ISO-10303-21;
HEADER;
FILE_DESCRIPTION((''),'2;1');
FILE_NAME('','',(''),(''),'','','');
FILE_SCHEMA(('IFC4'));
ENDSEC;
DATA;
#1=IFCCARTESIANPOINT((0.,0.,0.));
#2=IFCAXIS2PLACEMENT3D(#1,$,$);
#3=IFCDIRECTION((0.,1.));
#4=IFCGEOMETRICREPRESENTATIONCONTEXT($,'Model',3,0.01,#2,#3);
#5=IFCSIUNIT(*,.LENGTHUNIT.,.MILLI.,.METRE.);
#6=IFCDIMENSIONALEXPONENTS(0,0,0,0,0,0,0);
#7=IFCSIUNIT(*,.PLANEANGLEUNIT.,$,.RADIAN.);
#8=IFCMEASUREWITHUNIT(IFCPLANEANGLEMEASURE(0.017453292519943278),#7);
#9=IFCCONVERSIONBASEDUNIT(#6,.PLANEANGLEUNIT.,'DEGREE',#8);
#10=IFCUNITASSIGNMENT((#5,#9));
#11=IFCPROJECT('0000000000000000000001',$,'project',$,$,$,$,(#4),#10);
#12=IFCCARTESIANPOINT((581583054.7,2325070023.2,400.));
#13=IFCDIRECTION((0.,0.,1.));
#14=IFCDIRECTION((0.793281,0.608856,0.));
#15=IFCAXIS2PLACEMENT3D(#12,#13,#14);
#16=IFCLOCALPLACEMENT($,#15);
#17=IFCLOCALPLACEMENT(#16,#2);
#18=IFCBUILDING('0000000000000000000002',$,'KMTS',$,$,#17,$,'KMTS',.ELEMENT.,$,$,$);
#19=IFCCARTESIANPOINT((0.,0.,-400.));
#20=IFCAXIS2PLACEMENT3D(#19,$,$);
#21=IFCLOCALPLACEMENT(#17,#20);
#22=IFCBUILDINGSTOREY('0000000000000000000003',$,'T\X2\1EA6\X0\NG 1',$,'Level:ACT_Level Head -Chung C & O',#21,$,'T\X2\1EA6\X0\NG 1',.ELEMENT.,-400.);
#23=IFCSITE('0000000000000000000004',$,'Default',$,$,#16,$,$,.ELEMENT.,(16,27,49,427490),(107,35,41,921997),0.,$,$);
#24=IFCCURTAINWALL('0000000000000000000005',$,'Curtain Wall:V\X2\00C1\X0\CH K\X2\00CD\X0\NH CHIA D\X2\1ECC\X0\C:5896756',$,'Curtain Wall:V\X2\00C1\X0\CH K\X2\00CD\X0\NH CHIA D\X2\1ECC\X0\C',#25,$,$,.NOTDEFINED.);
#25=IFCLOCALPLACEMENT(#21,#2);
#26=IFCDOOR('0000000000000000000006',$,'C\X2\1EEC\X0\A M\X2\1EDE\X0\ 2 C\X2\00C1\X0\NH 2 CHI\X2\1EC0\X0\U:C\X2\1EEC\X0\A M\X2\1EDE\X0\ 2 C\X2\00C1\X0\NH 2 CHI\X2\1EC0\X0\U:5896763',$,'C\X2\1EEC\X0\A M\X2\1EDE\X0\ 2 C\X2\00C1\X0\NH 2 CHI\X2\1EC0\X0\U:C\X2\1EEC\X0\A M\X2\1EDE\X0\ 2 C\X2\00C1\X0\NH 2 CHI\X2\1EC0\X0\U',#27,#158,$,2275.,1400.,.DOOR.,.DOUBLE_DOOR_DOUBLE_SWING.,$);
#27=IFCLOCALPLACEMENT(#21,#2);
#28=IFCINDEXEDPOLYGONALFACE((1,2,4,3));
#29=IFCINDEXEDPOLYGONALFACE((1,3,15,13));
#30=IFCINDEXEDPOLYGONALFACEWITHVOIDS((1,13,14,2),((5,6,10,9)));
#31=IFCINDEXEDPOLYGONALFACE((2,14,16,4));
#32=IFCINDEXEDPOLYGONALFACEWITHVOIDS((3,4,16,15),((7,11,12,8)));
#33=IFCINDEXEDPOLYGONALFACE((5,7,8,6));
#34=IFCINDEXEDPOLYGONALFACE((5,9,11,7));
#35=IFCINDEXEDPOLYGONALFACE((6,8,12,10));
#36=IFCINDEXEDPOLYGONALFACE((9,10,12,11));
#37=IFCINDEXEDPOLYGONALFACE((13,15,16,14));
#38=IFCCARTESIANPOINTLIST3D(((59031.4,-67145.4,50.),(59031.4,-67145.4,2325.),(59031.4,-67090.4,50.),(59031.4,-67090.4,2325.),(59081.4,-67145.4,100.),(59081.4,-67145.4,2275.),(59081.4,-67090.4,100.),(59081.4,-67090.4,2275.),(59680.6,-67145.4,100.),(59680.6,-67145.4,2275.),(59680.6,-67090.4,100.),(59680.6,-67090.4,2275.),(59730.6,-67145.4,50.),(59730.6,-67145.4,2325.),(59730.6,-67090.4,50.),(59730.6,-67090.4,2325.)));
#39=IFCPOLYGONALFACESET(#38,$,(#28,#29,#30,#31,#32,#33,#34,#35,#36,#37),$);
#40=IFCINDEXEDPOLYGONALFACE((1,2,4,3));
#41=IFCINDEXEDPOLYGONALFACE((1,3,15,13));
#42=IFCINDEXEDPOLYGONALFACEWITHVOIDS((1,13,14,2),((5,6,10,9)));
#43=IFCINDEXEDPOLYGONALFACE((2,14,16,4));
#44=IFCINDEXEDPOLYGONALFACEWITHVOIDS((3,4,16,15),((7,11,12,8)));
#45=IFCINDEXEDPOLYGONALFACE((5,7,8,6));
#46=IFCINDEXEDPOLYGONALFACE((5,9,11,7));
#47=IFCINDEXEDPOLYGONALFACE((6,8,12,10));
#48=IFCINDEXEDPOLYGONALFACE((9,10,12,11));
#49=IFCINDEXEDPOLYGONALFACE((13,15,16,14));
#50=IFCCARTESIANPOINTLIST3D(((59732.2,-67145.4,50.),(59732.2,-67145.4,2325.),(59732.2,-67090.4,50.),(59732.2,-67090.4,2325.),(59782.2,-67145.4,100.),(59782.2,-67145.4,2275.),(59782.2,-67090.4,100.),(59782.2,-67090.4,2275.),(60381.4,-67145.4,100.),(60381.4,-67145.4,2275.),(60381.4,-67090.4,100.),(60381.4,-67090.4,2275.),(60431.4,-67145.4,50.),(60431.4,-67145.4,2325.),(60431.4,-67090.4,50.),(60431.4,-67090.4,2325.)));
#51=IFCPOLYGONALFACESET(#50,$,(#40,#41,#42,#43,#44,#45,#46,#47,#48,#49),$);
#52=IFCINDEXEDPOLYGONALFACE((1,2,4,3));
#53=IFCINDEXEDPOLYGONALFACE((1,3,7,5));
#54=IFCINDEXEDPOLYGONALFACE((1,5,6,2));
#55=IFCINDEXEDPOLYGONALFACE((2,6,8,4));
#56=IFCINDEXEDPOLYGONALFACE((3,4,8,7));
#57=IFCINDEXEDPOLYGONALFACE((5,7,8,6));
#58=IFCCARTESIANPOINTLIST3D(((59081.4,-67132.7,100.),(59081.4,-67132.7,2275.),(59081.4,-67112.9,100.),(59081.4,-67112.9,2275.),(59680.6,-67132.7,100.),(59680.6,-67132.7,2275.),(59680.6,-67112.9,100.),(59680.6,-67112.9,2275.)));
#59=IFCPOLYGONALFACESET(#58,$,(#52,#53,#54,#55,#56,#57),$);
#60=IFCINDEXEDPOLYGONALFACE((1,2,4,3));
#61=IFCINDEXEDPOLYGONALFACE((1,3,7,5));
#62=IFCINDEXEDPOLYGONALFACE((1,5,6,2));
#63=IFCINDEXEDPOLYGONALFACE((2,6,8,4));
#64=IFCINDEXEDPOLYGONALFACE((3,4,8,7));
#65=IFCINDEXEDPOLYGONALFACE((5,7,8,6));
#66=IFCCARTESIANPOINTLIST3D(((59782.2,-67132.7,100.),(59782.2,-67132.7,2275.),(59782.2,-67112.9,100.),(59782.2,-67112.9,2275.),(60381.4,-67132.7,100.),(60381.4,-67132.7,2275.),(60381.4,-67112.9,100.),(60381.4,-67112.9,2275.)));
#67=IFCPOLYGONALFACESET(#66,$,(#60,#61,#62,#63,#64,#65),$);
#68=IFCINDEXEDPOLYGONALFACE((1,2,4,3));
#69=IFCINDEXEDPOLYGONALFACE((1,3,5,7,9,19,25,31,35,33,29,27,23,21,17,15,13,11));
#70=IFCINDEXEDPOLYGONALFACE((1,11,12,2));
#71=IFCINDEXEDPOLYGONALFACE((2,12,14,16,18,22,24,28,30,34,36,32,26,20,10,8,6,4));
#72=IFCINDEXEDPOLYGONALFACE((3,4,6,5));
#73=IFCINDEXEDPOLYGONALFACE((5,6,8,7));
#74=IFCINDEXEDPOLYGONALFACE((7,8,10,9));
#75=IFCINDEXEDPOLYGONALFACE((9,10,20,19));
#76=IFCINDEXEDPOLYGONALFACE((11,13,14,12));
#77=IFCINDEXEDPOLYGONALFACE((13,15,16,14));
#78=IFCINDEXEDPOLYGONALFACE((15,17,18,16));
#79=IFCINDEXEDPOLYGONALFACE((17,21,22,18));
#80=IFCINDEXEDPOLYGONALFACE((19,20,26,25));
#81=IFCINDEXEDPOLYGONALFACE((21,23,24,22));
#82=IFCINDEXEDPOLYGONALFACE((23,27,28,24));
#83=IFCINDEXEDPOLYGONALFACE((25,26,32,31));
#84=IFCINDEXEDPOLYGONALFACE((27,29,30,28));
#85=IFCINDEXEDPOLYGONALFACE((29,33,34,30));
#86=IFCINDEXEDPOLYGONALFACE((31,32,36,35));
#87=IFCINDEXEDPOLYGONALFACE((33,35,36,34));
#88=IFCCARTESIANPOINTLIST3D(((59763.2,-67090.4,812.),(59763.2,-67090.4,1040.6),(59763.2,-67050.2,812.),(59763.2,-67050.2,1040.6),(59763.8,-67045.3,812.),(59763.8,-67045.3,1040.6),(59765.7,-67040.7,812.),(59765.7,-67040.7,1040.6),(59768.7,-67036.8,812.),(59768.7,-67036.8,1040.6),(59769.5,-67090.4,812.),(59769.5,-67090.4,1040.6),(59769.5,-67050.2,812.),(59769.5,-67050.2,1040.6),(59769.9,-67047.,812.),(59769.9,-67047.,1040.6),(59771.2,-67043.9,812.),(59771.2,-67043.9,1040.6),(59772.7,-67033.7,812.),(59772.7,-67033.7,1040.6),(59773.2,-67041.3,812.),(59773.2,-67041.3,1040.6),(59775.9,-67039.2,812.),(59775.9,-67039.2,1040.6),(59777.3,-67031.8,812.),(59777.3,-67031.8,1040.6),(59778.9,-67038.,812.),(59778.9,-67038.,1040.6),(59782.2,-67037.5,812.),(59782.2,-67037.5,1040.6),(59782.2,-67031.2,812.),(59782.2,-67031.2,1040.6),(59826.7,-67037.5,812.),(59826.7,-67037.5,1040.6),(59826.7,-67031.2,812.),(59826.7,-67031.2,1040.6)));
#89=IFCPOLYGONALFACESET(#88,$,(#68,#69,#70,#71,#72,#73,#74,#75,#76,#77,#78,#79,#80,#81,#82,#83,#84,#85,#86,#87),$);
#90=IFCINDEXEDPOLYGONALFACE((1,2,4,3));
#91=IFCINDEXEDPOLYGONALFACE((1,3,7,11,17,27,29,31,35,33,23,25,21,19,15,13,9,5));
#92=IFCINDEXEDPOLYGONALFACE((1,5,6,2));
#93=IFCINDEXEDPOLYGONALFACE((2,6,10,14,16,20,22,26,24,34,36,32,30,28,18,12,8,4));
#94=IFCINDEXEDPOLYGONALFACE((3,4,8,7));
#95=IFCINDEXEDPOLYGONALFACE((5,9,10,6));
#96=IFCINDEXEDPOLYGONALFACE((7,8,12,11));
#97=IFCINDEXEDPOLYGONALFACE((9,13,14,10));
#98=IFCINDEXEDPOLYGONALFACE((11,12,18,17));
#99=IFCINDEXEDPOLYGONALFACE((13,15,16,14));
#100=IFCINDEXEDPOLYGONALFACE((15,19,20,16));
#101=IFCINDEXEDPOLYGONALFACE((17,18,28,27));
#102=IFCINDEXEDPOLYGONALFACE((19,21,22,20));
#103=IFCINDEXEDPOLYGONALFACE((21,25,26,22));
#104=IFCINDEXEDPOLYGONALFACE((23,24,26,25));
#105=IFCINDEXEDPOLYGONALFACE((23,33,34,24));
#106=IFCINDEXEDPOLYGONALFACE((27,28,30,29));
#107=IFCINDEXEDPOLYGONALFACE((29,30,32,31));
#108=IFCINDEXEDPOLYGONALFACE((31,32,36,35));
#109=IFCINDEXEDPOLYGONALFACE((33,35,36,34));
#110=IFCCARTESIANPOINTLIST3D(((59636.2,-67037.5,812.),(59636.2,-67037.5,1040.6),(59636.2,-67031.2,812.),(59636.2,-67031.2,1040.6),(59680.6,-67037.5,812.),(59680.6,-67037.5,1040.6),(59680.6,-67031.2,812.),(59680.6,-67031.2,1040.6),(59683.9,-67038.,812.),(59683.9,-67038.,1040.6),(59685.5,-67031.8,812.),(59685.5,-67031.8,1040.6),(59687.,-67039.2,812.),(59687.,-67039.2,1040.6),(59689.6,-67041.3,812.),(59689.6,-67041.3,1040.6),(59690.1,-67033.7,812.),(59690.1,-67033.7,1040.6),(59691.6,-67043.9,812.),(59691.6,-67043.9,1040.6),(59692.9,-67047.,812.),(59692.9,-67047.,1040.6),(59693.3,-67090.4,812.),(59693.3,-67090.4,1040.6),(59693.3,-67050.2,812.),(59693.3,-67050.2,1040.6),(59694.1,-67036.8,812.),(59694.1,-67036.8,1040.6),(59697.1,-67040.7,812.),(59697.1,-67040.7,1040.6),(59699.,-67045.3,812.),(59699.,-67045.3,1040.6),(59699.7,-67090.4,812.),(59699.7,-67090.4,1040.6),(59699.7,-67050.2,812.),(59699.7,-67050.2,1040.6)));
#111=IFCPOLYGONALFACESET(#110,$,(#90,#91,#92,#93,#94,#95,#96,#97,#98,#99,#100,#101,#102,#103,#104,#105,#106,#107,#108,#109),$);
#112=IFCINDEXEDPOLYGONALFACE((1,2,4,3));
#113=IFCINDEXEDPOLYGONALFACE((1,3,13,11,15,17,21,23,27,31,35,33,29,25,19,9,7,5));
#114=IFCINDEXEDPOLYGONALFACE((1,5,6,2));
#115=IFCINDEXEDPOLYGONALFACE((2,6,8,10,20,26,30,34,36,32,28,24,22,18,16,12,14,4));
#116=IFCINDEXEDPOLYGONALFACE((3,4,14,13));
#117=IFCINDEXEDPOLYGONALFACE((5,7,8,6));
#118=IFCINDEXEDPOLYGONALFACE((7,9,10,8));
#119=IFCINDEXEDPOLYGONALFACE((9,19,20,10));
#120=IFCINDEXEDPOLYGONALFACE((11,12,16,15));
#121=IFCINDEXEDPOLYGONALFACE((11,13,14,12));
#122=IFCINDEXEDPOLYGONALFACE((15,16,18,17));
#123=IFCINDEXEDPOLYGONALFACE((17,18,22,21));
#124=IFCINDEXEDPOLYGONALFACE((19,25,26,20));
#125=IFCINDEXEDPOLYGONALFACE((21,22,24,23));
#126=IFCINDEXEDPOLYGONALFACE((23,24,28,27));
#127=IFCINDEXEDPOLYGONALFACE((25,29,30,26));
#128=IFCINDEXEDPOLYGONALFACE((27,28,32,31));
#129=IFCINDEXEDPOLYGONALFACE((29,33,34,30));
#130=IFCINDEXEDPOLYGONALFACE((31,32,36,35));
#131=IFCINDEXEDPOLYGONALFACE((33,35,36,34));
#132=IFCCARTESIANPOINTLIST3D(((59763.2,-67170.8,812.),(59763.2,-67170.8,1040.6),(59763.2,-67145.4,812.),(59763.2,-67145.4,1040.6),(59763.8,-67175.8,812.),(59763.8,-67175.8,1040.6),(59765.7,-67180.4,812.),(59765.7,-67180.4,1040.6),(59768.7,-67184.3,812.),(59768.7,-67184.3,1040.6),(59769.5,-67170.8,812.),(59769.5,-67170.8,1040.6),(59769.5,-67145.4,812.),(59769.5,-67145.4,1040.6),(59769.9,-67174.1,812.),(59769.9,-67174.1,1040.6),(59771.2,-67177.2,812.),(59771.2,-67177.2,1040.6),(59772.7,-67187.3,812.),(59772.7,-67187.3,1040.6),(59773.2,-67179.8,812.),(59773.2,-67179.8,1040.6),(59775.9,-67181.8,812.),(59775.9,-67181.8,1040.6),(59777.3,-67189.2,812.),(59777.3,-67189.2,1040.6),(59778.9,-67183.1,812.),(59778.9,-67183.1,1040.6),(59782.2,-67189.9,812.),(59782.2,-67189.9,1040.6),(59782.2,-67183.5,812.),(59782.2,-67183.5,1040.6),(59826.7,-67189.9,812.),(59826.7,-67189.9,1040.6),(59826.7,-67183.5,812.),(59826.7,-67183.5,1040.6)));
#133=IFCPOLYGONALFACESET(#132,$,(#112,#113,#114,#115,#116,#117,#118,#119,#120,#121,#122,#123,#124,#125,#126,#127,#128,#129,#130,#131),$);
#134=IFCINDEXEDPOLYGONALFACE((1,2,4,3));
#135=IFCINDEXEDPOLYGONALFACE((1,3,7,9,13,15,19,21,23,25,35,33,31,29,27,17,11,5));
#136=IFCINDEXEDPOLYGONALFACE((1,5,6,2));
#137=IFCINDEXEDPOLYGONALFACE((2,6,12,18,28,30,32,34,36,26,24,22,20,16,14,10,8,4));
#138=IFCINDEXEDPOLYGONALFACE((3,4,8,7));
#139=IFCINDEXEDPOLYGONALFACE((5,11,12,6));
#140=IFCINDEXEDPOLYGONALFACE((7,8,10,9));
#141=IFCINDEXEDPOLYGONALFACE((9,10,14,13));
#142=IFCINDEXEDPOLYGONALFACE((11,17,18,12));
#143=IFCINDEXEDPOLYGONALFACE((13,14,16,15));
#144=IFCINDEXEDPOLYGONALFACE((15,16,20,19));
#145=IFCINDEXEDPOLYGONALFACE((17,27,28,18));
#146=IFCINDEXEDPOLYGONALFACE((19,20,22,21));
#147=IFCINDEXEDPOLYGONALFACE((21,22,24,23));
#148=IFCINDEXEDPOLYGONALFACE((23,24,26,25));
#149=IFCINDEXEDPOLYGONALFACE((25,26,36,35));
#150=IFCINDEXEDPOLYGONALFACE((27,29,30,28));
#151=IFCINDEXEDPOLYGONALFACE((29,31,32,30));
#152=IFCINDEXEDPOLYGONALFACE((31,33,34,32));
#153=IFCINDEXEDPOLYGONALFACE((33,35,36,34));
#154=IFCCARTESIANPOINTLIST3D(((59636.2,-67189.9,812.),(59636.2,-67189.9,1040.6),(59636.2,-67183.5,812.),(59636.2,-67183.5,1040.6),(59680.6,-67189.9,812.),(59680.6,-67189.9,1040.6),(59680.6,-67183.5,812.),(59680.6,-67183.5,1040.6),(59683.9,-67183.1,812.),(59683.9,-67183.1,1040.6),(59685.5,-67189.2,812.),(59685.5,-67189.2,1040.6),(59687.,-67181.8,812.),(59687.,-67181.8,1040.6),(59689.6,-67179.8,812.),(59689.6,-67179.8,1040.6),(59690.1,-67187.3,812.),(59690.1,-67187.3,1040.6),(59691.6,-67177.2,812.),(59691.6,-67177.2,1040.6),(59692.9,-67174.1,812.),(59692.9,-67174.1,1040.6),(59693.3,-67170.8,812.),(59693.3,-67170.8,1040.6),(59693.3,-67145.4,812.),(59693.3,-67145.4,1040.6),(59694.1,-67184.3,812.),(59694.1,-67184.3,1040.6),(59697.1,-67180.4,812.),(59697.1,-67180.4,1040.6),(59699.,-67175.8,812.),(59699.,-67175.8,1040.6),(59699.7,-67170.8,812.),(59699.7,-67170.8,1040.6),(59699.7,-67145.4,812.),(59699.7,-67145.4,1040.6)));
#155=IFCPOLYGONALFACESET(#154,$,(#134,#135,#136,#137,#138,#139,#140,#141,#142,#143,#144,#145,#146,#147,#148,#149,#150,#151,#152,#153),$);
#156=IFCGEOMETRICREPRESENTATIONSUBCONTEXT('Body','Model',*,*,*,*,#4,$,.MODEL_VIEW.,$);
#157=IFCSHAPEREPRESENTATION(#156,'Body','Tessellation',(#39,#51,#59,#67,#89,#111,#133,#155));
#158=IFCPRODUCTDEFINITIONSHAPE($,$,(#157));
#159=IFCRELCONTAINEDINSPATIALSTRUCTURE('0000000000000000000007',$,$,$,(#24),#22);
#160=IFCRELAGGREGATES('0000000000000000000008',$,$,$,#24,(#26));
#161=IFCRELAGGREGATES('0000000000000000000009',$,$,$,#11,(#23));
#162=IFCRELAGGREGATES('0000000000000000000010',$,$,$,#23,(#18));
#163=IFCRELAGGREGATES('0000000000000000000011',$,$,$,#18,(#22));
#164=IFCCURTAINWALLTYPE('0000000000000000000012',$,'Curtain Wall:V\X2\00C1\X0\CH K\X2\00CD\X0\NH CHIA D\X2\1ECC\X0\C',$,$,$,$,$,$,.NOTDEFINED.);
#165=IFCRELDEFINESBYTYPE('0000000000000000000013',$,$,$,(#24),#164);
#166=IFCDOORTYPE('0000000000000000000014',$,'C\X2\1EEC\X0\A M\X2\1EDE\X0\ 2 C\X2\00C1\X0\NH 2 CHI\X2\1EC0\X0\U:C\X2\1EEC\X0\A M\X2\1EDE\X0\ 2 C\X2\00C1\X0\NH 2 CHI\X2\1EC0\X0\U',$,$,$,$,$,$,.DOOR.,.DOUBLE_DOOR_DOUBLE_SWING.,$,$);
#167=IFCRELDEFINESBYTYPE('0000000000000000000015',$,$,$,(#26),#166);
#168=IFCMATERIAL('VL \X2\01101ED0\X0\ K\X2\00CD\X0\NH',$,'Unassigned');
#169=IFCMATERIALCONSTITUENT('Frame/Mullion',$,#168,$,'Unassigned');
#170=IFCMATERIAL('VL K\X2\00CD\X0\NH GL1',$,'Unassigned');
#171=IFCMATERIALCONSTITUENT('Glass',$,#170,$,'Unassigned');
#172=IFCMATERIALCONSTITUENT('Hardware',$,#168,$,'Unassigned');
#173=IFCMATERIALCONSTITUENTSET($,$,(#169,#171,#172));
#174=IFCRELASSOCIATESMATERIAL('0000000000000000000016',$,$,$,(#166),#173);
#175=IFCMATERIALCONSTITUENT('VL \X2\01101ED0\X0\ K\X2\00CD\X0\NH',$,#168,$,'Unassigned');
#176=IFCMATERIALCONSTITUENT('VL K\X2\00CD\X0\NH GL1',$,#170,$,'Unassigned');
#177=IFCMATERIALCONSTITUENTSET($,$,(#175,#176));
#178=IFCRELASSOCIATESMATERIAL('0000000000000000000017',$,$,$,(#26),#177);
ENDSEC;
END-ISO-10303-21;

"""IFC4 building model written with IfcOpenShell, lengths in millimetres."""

from ifc_helpers import new_model, entity, si_unit, converted_unit, direction, frame, origin, place, context, subcontext, project, spatial, line, arc, indexed_curve, outline, extrude, source, transform, mapped, material, constituent, constituent_set, type_object, type_shapes, element, aggregate, save


model = new_model("IFC4")

# Units and contexts
model_context = context("Model", 3, precision=0.01, world=origin(), true_north=direction((0.0, 1.0)))
body_context = subcontext(model_context, "Body", "Model", "MODEL_VIEW")
ifc_project = project(units=[si_unit("LENGTHUNIT", "METRE", prefix="MILLI"), converted_unit("PLANEANGLEUNIT", "DEGREE", entity("IfcPlaneAngleMeasure", 0.017453292519943278), si_unit("PLANEANGLEUNIT", "RADIAN"), dimensions=[0, 0, 0, 0, 0, 0, 0])], contexts=[model_context])

# Site, building, storey
site_placement = place(None, frame((581583054.7, 2325070023.2, 400.0), z_axis=(0.0, 0.0, 1.0), x_axis=(0.793281, 0.608856, 0.0)))
site = spatial("IfcSite", under=ifc_project, at=site_placement, Name="Default", CompositionType="ELEMENT", RefLatitude=(16, 27, 49, 427490), RefLongitude=(107, 35, 41, 921997), RefElevation=0.0)
building_placement = place(site_placement, origin())
building = spatial("IfcBuilding", under=site, at=building_placement, Name="KMTS", LongName="KMTS", CompositionType="ELEMENT")
storey_placement = place(building_placement, frame((0.0, 0.0, -400.0)))
storey = spatial("IfcBuildingStorey", under=building, at=storey_placement, Name="TẦNG 1", ObjectType="Level:ACT_Level Head -Chung C & O", LongName="TẦNG 1", CompositionType="ELEMENT", Elevation=-400.0)

# Curtain wall
curtain_wall_type = type_object("IfcCurtainWallType", Name="Curtain Wall:VÁCH KÍNH CHIA DỌC", PredefinedType="NOTDEFINED")
curtain_wall_1_placement = place(storey_placement, frame((0.0, 0.0, 400.0)))
curtain_wall_1 = element("IfcCurtainWall", 1, at=curtain_wall_1_placement, inside=storey, type_object=curtain_wall_type, Name="Curtain Wall:VÁCH KÍNH CHIA DỌC:5896756", ObjectType="Curtain Wall:VÁCH KÍNH CHIA DỌC", PredefinedType="NOTDEFINED")
ifc_material_1 = material(Name="VL ĐỐ KÍNH", Category="Unassigned")

# Door
ifc_constituent_1 = constituent(ifc_material_1, Name="VL ĐỐ KÍNH", Category="Unassigned")
ifc_material_2 = material(Name="VL KÍNH GL1", Category="Unassigned")
ifc_constituent_2 = constituent(ifc_material_2, Name="VL KÍNH GL1", Category="Unassigned")
ifc_constituent_set_1 = constituent_set(constituents=[ifc_constituent_1, ifc_constituent_2])
ifc_constituent_3 = constituent(ifc_material_1, Name="Frame/Mullion", Category="Unassigned")
ifc_constituent_4 = constituent(ifc_material_2, Name="Glass", Category="Unassigned")
ifc_constituent_5 = constituent(ifc_material_1, Name="Hardware", Category="Unassigned")
ifc_constituent_set_2 = constituent_set(constituents=[ifc_constituent_3, ifc_constituent_4, ifc_constituent_5])
door_type_1 = type_object("IfcDoorType", Name="CỬA MỞ 2 CÁNH 2 CHIỀU:CỬA MỞ 2 CÁNH 2 CHIỀU", OperationType="DOUBLE_DOOR_DOUBLE_SWING", PredefinedType="DOOR", material=ifc_constituent_set_2)
shared_shape_1 = source(origin(), body_context, "Body", "SweptSolid", [
    extrude(outline(indexed_curve([(-1137.5, -349.6), (1137.5, -349.6), (1137.5, 349.6), (-1137.5, 349.6), (-1137.5, -349.6)], self_intersect=False), holes=[indexed_curve([(-1087.5, 299.6), (1087.5, 299.6), (1087.5, -299.6), (-1087.5, -299.6), (-1087.5, 299.6)], self_intersect=False)]), frame((350.4, 27.5, 1137.5), z_axis=(0.0, -1.0, 0.0), x_axis=(0.0, 0.0, -1.0)), (0.0, 0.0, 1.0), 55.0),
    extrude(outline(indexed_curve([(-349.6, -1137.5), (349.6, -1137.5), (349.6, 1137.5), (-349.6, 1137.5), (-349.6, -1137.5)], self_intersect=False), holes=[indexed_curve([(-299.6, -1087.5), (-299.6, 1087.5), (299.6, 1087.5), (299.6, -1087.5), (-299.6, -1087.5)], self_intersect=False)]), frame((-350.4, 27.5, 1137.5), z_axis=(0.0, -1.0, 0.0), x_axis=(-1.0, 0.0, 0.0)), (0.0, 0.0, 1.0), 55.0),
    extrude(outline(indexed_curve([(-299.6, -9.9), (299.6, -9.9), (299.6, 9.9), (-299.6, 9.9), (-299.6, -9.9)], self_intersect=False)), frame((350.4, 4.9, 50.0)), (0.0, 0.0, 1.0), 2175.0),
    extrude(outline(indexed_curve([(-299.6, -9.9), (299.6, -9.9), (299.6, 9.9), (-299.6, 9.9), (-299.6, -9.9)], self_intersect=False)), frame((-350.4, 4.9, 50.0)), (0.0, 0.0, 1.0), 2175.0),
    extrude(outline(indexed_curve([(-2.1, -22.2), (38.1, -22.2), (38.1, -15.9), (-2.1, -15.9), (-11.1, -12.2), (-14.8, -3.2), (-14.8, 41.3), (-21.2, 41.3), (-21.2, -3.2), (-15.6, -16.6)], segments=[line(1, 2, 3, 4), arc(4, 5, 6), line(6, 7, 8, 9), arc(9, 10, 1)], self_intersect=False)), frame((-54.0, -65.6, 762.0), z_axis=(0.0, 0.0, 1.0), x_axis=(0.0, 1.0, 0.0)), (0.0, 0.0, 1.0), 228.6),
    extrude(outline(indexed_curve([(22.2, 2.1), (16.6, 15.6), (3.2, 21.2), (-41.3, 21.2), (-41.3, 14.8), (3.2, 14.8), (12.2, 11.1), (15.9, 2.1), (15.9, -38.1), (22.2, -38.1)], segments=[arc(1, 2, 3), line(3, 4, 5, 6), arc(6, 7, 8), line(8, 9, 10, 1)], self_intersect=False)), frame((54.0, -65.6, 762.0), z_axis=(0.0, 0.0, 1.0), x_axis=(-1.0, 0.0, 0.0)), (0.0, 0.0, 1.0), 228.6),
    extrude(outline(indexed_curve([(-22.2, 1.6), (-16.6, -11.9), (-3.2, -17.5), (41.3, -17.5), (41.3, -11.1), (-3.2, -11.1), (-12.2, -7.4), (-15.9, 1.6), (-15.9, 27.0), (-22.2, 27.0)], segments=[arc(1, 2, 3), line(3, 4, 5, 6), arc(6, 7, 8), line(8, 9, 10, 1)], self_intersect=False)), frame((-54.0, 54.5, 762.0), z_axis=(0.0, 0.0, 1.0), x_axis=(-1.0, 0.0, 0.0)), (0.0, 0.0, 1.0), 228.6),
    extrude(outline(indexed_curve([(1.6, -22.2), (27.0, -22.2), (27.0, -15.9), (1.6, -15.9), (-7.4, -12.2), (-11.1, -3.2), (-11.1, 41.3), (-17.5, 41.3), (-17.5, -3.2), (-11.9, -16.6)], segments=[line(1, 2, 3, 4), arc(4, 5, 6), line(6, 7, 8, 9), arc(9, 10, 1)], self_intersect=False)), frame((54.0, 54.5, 762.0), z_axis=(0.0, 0.0, 1.0), x_axis=(0.0, -1.0, 0.0)), (0.0, 0.0, 1.0), 228.6),
])
type_shapes(door_type_1, [shared_shape_1])
door_1_placement = place(curtain_wall_1_placement, frame((59731.4, -67117.9, -350.0), z_axis=(0.0, 0.0, 1.0), x_axis=(-1.0, 0.0, 0.0)))
door_1 = element("IfcDoor", 2, at=door_1_placement, type_object=door_type_1, material=ifc_constituent_set_1, Name="CỬA MỞ 2 CÁNH 2 CHIỀU:CỬA MỞ 2 CÁNH 2 CHIỀU:5896763", ObjectType="CỬA MỞ 2 CÁNH 2 CHIỀU:CỬA MỞ 2 CÁNH 2 CHIỀU", OperationType="DOUBLE_DOOR_DOUBLE_SWING", OverallHeight=2275.0, OverallWidth=1400.0, PredefinedType="DOOR", context=body_context, shape_type="MappedRepresentation", body=[
    mapped(shared_shape_1, transform((0.0, 0.0, 0.0), scale=1.0)),
])
aggregate(curtain_wall_1, [door_1])

save(model, "model.ifc")
